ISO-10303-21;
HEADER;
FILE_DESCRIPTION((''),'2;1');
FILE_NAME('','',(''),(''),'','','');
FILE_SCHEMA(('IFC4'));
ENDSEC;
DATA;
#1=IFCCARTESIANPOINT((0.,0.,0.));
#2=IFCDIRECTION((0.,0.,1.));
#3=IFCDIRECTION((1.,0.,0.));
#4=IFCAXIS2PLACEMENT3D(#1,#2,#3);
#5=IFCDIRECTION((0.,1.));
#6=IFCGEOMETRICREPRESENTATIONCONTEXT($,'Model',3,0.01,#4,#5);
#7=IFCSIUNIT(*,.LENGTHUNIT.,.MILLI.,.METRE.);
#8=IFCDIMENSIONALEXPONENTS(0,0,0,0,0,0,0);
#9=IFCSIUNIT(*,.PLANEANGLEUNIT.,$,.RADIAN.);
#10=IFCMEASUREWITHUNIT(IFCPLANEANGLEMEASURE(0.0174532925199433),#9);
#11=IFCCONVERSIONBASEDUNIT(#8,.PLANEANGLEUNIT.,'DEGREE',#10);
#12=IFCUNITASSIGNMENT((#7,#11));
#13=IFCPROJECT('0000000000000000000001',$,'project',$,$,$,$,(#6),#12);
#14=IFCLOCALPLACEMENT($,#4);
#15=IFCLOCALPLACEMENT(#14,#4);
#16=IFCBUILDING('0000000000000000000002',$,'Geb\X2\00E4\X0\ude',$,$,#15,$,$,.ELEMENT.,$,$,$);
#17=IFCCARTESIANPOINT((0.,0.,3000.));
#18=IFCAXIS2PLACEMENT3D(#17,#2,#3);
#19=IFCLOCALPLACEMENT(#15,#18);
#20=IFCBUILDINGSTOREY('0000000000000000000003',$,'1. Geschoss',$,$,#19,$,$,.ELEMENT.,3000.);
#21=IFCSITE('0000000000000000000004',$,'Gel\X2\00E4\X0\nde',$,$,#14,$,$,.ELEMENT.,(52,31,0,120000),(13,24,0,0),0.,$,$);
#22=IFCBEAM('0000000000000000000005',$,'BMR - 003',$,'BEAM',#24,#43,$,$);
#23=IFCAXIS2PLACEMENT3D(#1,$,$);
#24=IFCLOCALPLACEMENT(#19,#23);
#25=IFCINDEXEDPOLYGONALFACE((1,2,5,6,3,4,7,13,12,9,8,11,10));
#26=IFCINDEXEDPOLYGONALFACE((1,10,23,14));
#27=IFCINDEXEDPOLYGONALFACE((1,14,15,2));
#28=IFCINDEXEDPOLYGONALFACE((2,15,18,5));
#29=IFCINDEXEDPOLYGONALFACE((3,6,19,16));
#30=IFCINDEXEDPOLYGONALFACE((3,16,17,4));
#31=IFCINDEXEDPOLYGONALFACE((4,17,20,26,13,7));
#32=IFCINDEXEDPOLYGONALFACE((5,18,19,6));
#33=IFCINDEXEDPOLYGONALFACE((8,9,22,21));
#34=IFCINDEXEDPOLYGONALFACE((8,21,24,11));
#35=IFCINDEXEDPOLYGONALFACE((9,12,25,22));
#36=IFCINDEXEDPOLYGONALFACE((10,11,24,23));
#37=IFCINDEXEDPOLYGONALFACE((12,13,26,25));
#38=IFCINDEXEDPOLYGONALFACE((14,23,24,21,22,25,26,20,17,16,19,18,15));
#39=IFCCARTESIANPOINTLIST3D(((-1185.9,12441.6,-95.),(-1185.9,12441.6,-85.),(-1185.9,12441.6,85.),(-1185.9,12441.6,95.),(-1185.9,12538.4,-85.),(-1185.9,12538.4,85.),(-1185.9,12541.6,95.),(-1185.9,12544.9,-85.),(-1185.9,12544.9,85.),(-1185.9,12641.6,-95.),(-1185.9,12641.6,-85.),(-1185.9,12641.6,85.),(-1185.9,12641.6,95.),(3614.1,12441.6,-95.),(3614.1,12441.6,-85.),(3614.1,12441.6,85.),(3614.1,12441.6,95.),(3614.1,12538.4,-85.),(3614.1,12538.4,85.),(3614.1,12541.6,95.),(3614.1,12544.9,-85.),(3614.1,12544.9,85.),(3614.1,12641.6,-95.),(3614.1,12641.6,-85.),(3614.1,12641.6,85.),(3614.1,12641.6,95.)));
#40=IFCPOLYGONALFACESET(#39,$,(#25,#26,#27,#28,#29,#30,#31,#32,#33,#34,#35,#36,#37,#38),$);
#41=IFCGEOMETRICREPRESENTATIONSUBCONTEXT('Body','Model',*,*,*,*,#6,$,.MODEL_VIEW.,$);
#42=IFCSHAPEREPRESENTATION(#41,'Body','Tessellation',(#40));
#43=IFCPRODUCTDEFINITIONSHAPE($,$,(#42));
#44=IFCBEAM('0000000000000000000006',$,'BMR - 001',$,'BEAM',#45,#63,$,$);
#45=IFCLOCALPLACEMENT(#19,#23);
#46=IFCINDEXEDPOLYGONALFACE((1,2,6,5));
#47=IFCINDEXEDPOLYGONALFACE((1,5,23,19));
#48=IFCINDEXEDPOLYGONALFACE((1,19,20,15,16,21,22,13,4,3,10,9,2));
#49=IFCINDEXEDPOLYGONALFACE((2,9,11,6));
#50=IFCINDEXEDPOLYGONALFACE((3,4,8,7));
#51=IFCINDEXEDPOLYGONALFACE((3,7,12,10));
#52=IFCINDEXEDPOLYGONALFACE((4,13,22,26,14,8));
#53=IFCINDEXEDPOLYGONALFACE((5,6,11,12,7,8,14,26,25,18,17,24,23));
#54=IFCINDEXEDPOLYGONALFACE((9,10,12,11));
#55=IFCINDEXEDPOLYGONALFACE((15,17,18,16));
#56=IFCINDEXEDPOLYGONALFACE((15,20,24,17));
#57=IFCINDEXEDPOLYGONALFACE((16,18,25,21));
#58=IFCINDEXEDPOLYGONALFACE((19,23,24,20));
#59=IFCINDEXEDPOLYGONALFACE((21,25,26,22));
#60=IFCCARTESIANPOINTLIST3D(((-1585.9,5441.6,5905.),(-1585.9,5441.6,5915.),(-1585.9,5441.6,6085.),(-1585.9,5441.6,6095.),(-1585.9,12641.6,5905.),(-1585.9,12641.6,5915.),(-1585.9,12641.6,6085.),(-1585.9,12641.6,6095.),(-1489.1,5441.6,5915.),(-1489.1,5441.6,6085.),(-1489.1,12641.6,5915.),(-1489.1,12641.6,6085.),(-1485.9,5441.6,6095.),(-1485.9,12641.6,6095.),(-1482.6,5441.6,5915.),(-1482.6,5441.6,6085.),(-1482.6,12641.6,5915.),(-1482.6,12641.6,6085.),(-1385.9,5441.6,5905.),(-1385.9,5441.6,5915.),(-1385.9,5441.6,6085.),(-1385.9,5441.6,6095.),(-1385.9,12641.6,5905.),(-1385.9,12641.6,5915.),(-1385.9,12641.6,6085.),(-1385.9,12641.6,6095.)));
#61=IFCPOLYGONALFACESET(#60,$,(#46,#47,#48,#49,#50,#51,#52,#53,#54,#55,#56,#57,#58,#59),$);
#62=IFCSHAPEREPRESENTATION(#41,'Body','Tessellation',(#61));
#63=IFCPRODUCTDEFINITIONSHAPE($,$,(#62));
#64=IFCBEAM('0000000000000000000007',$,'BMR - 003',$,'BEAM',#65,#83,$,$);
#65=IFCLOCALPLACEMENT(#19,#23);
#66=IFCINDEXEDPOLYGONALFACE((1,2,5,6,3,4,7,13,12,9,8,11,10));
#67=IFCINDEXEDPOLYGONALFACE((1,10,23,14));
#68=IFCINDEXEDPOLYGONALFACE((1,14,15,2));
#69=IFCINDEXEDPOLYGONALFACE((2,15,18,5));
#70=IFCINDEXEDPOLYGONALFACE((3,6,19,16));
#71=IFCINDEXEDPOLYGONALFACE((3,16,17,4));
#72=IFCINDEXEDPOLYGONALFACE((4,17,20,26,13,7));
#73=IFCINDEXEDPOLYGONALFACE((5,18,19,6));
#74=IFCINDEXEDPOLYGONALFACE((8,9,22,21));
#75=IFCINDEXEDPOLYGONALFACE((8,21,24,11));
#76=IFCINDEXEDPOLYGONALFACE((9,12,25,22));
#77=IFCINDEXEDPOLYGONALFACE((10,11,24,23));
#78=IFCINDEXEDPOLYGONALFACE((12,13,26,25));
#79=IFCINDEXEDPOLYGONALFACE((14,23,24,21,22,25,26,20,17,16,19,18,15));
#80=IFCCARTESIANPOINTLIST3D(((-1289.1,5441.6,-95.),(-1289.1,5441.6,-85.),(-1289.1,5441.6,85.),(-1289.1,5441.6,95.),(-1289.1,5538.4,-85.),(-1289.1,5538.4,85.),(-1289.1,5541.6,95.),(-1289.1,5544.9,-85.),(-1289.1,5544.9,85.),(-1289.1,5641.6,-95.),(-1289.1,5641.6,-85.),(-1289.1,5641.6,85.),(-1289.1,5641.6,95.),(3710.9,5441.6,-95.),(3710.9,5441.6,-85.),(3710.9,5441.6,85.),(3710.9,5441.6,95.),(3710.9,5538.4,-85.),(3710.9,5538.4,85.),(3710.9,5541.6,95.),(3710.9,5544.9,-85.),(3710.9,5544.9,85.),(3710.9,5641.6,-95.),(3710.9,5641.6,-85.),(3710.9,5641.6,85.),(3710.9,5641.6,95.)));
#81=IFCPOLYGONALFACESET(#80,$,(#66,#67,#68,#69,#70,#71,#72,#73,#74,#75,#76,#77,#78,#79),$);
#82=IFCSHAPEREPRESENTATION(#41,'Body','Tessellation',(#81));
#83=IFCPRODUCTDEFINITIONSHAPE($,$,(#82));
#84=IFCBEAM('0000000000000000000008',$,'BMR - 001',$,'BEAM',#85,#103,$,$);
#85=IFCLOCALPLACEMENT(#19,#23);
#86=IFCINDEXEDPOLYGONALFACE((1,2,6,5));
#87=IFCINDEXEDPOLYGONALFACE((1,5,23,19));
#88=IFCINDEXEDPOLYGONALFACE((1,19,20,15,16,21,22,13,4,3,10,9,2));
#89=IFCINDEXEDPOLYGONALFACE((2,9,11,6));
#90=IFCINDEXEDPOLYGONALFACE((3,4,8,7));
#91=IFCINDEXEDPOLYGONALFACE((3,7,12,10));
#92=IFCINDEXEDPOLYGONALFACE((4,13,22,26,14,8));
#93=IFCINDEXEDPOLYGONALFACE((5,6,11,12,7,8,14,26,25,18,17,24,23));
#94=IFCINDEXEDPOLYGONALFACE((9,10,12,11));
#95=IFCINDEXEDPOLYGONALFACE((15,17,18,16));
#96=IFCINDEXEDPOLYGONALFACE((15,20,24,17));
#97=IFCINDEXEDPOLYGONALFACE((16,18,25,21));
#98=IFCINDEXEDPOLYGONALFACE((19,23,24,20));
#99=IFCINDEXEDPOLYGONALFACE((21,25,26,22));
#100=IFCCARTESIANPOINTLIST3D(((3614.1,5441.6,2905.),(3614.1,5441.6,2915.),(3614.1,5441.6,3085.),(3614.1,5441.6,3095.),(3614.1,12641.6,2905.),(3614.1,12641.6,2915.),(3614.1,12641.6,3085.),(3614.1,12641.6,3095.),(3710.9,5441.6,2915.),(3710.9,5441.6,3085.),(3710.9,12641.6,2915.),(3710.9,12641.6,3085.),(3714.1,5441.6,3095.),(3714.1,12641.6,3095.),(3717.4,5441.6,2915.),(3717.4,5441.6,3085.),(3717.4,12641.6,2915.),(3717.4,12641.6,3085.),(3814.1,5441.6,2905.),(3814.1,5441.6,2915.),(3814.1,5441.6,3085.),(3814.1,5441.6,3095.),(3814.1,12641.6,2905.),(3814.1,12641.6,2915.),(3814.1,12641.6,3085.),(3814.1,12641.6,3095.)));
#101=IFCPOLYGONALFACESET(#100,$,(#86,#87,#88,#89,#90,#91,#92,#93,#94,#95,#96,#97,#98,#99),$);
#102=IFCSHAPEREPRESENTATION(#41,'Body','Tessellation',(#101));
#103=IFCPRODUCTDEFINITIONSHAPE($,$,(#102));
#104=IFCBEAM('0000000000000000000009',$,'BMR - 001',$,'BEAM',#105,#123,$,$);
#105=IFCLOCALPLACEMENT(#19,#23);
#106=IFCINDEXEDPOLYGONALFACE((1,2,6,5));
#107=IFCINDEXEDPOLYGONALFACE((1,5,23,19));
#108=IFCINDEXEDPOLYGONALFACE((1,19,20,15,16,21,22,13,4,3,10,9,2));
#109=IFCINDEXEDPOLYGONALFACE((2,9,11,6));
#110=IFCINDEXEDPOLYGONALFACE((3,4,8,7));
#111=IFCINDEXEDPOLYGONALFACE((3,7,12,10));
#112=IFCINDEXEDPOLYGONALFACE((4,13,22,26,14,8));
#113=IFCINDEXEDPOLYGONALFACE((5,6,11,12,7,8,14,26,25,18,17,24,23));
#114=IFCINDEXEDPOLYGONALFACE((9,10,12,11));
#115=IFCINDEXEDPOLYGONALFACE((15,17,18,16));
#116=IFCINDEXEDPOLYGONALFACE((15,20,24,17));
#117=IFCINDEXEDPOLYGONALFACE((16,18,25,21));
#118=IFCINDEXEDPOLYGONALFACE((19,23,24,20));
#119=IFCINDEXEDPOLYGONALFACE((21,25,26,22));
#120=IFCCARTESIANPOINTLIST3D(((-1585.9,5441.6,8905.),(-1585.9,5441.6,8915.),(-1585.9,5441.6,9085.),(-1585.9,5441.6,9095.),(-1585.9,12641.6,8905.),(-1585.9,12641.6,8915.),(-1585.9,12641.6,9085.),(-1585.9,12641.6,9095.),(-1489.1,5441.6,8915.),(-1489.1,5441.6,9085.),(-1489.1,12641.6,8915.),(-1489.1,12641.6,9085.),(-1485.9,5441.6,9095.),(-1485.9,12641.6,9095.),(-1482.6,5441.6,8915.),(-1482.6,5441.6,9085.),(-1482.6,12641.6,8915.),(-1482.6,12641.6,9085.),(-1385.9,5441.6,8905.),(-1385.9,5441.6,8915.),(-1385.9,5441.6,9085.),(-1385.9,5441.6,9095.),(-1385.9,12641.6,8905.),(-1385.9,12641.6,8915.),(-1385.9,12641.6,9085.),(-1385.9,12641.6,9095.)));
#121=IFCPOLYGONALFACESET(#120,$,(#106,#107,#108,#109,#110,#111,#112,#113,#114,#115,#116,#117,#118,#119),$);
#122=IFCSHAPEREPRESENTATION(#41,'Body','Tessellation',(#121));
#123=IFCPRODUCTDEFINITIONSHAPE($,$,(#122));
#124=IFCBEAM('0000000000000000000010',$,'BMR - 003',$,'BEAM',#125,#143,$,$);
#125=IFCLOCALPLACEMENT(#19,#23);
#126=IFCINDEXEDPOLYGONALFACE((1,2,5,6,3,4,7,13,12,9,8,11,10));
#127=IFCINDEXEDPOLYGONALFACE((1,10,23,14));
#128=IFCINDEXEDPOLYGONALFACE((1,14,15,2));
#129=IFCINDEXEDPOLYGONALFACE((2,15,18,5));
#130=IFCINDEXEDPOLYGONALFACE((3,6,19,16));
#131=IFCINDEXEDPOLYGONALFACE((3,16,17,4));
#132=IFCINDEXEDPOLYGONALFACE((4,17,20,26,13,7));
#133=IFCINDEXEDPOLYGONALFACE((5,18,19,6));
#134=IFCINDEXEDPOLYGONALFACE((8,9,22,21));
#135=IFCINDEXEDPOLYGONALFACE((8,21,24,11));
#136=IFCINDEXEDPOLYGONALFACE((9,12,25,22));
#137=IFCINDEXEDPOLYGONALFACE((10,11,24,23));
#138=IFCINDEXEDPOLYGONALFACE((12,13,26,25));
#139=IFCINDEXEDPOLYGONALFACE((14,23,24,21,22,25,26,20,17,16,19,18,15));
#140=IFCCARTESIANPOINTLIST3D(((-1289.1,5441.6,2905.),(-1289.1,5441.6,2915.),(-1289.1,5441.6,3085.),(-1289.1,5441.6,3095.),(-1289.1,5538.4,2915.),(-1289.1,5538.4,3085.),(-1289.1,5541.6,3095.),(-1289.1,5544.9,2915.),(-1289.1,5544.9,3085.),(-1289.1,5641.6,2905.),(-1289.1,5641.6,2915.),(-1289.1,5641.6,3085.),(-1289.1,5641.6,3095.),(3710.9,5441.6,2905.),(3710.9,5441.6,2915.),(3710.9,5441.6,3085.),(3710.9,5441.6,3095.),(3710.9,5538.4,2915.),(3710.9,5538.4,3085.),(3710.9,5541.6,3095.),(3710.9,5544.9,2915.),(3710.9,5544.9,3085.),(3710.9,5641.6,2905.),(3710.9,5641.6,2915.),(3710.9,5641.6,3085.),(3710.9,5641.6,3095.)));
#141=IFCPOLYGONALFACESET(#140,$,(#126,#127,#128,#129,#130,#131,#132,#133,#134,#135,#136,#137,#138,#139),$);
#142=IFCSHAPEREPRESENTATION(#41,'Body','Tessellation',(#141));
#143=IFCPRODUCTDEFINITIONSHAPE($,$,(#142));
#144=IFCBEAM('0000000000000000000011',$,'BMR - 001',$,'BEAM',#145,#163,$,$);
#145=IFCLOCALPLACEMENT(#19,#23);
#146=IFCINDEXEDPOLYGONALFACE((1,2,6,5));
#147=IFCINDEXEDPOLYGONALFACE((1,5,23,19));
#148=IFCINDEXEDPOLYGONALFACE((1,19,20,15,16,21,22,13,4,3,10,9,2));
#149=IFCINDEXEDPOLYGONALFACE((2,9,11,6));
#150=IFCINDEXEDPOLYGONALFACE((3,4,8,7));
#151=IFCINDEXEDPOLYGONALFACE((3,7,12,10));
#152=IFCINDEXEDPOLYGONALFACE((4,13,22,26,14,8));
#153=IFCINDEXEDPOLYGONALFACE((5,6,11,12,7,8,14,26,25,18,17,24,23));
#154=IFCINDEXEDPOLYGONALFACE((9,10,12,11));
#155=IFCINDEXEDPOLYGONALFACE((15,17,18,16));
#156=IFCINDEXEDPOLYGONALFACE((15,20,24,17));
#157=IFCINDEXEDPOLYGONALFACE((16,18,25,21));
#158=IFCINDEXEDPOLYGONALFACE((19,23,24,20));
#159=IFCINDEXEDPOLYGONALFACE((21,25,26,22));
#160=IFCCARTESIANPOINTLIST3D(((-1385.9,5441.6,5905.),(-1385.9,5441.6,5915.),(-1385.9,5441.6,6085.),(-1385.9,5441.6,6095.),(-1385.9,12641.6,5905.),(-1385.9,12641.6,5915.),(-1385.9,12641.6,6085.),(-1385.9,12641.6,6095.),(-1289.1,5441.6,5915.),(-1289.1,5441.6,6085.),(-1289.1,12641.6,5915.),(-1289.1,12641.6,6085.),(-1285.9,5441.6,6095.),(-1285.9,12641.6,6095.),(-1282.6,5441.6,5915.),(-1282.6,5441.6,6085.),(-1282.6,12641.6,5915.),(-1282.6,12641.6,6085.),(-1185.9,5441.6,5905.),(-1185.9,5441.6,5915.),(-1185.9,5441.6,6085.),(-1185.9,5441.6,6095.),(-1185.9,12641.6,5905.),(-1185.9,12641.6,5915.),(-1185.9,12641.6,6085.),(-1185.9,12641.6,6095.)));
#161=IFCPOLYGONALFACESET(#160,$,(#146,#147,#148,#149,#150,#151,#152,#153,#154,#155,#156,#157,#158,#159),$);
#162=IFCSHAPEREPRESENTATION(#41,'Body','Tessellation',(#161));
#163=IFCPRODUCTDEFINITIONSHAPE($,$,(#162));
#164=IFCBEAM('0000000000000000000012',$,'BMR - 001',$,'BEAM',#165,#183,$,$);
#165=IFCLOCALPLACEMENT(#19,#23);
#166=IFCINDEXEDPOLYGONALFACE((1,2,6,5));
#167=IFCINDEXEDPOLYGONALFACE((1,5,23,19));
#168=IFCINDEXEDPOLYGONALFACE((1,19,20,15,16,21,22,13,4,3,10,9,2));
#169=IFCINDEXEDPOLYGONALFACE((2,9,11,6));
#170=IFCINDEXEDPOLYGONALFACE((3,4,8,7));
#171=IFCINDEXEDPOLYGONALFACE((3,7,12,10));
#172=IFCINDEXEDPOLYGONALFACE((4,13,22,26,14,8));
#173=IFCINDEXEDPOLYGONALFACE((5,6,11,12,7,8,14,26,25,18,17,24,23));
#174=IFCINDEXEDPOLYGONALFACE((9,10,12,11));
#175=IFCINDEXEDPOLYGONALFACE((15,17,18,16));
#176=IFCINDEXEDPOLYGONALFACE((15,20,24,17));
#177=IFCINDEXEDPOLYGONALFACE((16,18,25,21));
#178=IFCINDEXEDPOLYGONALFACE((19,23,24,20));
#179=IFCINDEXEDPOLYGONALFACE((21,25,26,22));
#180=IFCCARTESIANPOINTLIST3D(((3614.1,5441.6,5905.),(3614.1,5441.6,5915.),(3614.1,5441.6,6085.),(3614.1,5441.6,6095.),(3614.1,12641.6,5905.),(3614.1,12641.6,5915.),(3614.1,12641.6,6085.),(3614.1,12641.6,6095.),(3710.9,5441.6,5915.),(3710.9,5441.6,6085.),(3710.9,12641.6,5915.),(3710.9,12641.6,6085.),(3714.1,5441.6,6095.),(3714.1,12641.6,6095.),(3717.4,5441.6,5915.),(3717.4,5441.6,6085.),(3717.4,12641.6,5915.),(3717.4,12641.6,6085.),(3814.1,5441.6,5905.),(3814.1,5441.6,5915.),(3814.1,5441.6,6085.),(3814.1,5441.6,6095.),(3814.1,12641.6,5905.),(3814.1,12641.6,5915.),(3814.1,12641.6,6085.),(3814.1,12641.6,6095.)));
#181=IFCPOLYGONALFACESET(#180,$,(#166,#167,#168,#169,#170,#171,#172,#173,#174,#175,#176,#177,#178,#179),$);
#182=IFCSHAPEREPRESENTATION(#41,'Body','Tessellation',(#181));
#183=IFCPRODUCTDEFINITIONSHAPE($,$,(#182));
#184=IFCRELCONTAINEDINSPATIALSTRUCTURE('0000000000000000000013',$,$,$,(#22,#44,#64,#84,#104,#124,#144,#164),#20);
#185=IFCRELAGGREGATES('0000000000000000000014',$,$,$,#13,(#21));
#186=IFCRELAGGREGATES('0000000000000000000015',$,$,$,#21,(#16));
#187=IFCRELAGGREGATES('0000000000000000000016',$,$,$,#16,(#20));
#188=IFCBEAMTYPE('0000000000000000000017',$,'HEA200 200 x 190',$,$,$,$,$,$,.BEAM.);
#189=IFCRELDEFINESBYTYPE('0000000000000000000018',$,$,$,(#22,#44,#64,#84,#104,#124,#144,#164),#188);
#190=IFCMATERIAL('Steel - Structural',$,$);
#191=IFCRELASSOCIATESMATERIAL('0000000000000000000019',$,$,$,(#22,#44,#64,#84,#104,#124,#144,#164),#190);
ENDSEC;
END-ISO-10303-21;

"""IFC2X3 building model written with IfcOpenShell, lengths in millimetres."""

from ifc_helpers import new_model, entity, si_unit, converted_unit, direction, frame, origin_with_axes, place, context, subcontext, project, spatial, polyline, outline, extrude, material, type_object, element, save


model = new_model("IFC2X3")

# Units and contexts
model_context = context("Model", 3, precision=0.01, world=origin_with_axes(), true_north=direction((0.0, 1.0)))
body_context = subcontext(model_context, "Body", "Model", "MODEL_VIEW")
ifc_project = project(units=[si_unit("LENGTHUNIT", "METRE", prefix="MILLI"), converted_unit("PLANEANGLEUNIT", "DEGREE", entity("IfcPlaneAngleMeasure", 0.0174532925199433), si_unit("PLANEANGLEUNIT", "RADIAN"), dimensions=[0, 0, 0, 0, 0, 0, 0])], contexts=[model_context])

# Site, building, storey
site_placement = place(None, origin_with_axes())
site = spatial("IfcSite", under=ifc_project, at=site_placement, Name="Gelände", CompositionType="ELEMENT", RefLatitude=(52, 31, 0, 120000), RefLongitude=(13, 24, 0, 0), RefElevation=0.0)
building_placement = place(site_placement, origin_with_axes())
building = spatial("IfcBuilding", under=site, at=building_placement, Name="Gebäude", CompositionType="ELEMENT")
storey_placement = place(building_placement, frame((0.0, 0.0, 3000.0), z_axis=(0.0, 0.0, 1.0), x_axis=(1.0, 0.0, 0.0)))
storey = spatial("IfcBuildingStorey", under=building, at=storey_placement, Name="1. Geschoss", CompositionType="ELEMENT", Elevation=3000.0)

# Beams
ifc_material = material(Name="Steel - Structural")
beam_type = type_object("IfcBeamType", Name="HEA200 200 x 190", PredefinedType="BEAM")
beam_1_placement = place(storey_placement, frame((-1185.9, 12541.6, 0.0), z_axis=(0.0, 0.0, 1.0), x_axis=(0.0, -1.0, 0.0)))
element("IfcBeam", 1, at=beam_1_placement, inside=storey, type_object=beam_type, material=ifc_material, Name="BMR - 003", ObjectType="BEAM", context=body_context, shape_type="SweptSolid", body=[
    extrude(outline(polyline([(0.0, 95.0), (-100.0, 95.0), (-100.0, 85.0), (-3.2, 85.0), (-3.2, -85.0), (-100.0, -85.0), (-100.0, -95.0), (100.0, -95.0), (100.0, -85.0), (3.2, -85.0), (3.2, 85.0), (100.0, 85.0), (100.0, 95.0), (0.0, 95.0)])), frame((0.0, 4800.0, 0.0), z_axis=(0.0, -1.0, 0.0), x_axis=(1.0, 0.0, 0.0)), (0.0, 0.0, 1.0), 4800.0),
])
beam_2_placement = place(storey_placement, frame((-1485.9, 5441.6, 6000.0), z_axis=(0.0, 0.0, 1.0), x_axis=(1.0, 0.0, 0.0)))
element("IfcBeam", 2, at=beam_2_placement, inside=storey, type_object=beam_type, material=ifc_material, Name="BMR - 001", ObjectType="BEAM", context=body_context, shape_type="SweptSolid", body=[
    extrude(outline(polyline([(0.0, 95.0), (-100.0, 95.0), (-100.0, 85.0), (-3.2, 85.0), (-3.2, -85.0), (-100.0, -85.0), (-100.0, -95.0), (100.0, -95.0), (100.0, -85.0), (3.2, -85.0), (3.2, 85.0), (100.0, 85.0), (100.0, 95.0), (0.0, 95.0)])), frame((0.0, 7200.0, 0.0), z_axis=(0.0, -1.0, 0.0), x_axis=(1.0, 0.0, 0.0)), (0.0, 0.0, 1.0), 7200.0),
])
beam_3_placement = place(storey_placement, frame((-1289.1, 5541.6, 0.0), z_axis=(0.0, 0.0, 1.0), x_axis=(0.0, -1.0, 0.0)))
element("IfcBeam", 3, at=beam_3_placement, inside=storey, type_object=beam_type, material=ifc_material, Name="BMR - 003", ObjectType="BEAM", context=body_context, shape_type="SweptSolid", body=[
    extrude(outline(polyline([(0.0, 95.0), (-100.0, 95.0), (-100.0, 85.0), (-3.2, 85.0), (-3.2, -85.0), (-100.0, -85.0), (-100.0, -95.0), (100.0, -95.0), (100.0, -85.0), (3.2, -85.0), (3.2, 85.0), (100.0, 85.0), (100.0, 95.0), (0.0, 95.0)])), frame((0.0, 5000.0, 0.0), z_axis=(0.0, -1.0, 0.0), x_axis=(1.0, 0.0, 0.0)), (0.0, 0.0, 1.0), 5000.0),
])
beam_4_placement = place(storey_placement, frame((3714.1, 5441.6, 3000.0), z_axis=(0.0, 0.0, 1.0), x_axis=(1.0, 0.0, 0.0)))
element("IfcBeam", 4, at=beam_4_placement, inside=storey, type_object=beam_type, material=ifc_material, Name="BMR - 001", ObjectType="BEAM", context=body_context, shape_type="SweptSolid", body=[
    extrude(outline(polyline([(0.0, 95.0), (-100.0, 95.0), (-100.0, 85.0), (-3.2, 85.0), (-3.2, -85.0), (-100.0, -85.0), (-100.0, -95.0), (100.0, -95.0), (100.0, -85.0), (3.2, -85.0), (3.2, 85.0), (100.0, 85.0), (100.0, 95.0), (0.0, 95.0)])), frame((0.0, 7200.0, 0.0), z_axis=(0.0, -1.0, 0.0), x_axis=(1.0, 0.0, 0.0)), (0.0, 0.0, 1.0), 7200.0),
])
beam_5_placement = place(storey_placement, frame((-1485.9, 5441.6, 9000.0), z_axis=(0.0, 0.0, 1.0), x_axis=(1.0, 0.0, 0.0)))
element("IfcBeam", 5, at=beam_5_placement, inside=storey, type_object=beam_type, material=ifc_material, Name="BMR - 001", ObjectType="BEAM", context=body_context, shape_type="SweptSolid", body=[
    extrude(outline(polyline([(0.0, 95.0), (-100.0, 95.0), (-100.0, 85.0), (-3.2, 85.0), (-3.2, -85.0), (-100.0, -85.0), (-100.0, -95.0), (100.0, -95.0), (100.0, -85.0), (3.2, -85.0), (3.2, 85.0), (100.0, 85.0), (100.0, 95.0), (0.0, 95.0)])), frame((0.0, 7200.0, 0.0), z_axis=(0.0, -1.0, 0.0), x_axis=(1.0, 0.0, 0.0)), (0.0, 0.0, 1.0), 7200.0),
])
beam_6_placement = place(storey_placement, frame((-1289.1, 5541.6, 3000.0), z_axis=(0.0, 0.0, 1.0), x_axis=(0.0, -1.0, 0.0)))
element("IfcBeam", 6, at=beam_6_placement, inside=storey, type_object=beam_type, material=ifc_material, Name="BMR - 003", ObjectType="BEAM", context=body_context, shape_type="SweptSolid", body=[
    extrude(outline(polyline([(0.0, 95.0), (-100.0, 95.0), (-100.0, 85.0), (-3.2, 85.0), (-3.2, -85.0), (-100.0, -85.0), (-100.0, -95.0), (100.0, -95.0), (100.0, -85.0), (3.2, -85.0), (3.2, 85.0), (100.0, 85.0), (100.0, 95.0), (0.0, 95.0)])), frame((0.0, 5000.0, 0.0), z_axis=(0.0, -1.0, 0.0), x_axis=(1.0, 0.0, 0.0)), (0.0, 0.0, 1.0), 5000.0),
])
for number, where, z_axis, x_axis, name in (
    (7, (-1285.9, 5441.6, 6000.0), (0.0, 0.0, 1.0), (1.0, 0.0, 0.0), "BMR - 001"),
    (8, (3714.1, 5441.6, 6000.0), (0.0, 0.0, 1.0), (1.0, 0.0, 0.0), "BMR - 001"),
):
    element("IfcBeam", number, at=place(storey_placement, frame(where, z_axis=z_axis, x_axis=x_axis)), inside=storey, type_object=beam_type, material=ifc_material, Name=name, ObjectType="BEAM", context=body_context, shape_type="SweptSolid", body=[
        extrude(outline(polyline([(0.0, 95.0), (-100.0, 95.0), (-100.0, 85.0), (-3.2, 85.0), (-3.2, -85.0), (-100.0, -85.0), (-100.0, -95.0), (100.0, -95.0), (100.0, -85.0), (3.2, -85.0), (3.2, 85.0), (100.0, 85.0), (100.0, 95.0), (0.0, 95.0)])), frame((0.0, 7200.0, 0.0), z_axis=(0.0, -1.0, 0.0), x_axis=(1.0, 0.0, 0.0)), (0.0, 0.0, 1.0), 7200.0),
    ])

save(model, "model.ifc")
